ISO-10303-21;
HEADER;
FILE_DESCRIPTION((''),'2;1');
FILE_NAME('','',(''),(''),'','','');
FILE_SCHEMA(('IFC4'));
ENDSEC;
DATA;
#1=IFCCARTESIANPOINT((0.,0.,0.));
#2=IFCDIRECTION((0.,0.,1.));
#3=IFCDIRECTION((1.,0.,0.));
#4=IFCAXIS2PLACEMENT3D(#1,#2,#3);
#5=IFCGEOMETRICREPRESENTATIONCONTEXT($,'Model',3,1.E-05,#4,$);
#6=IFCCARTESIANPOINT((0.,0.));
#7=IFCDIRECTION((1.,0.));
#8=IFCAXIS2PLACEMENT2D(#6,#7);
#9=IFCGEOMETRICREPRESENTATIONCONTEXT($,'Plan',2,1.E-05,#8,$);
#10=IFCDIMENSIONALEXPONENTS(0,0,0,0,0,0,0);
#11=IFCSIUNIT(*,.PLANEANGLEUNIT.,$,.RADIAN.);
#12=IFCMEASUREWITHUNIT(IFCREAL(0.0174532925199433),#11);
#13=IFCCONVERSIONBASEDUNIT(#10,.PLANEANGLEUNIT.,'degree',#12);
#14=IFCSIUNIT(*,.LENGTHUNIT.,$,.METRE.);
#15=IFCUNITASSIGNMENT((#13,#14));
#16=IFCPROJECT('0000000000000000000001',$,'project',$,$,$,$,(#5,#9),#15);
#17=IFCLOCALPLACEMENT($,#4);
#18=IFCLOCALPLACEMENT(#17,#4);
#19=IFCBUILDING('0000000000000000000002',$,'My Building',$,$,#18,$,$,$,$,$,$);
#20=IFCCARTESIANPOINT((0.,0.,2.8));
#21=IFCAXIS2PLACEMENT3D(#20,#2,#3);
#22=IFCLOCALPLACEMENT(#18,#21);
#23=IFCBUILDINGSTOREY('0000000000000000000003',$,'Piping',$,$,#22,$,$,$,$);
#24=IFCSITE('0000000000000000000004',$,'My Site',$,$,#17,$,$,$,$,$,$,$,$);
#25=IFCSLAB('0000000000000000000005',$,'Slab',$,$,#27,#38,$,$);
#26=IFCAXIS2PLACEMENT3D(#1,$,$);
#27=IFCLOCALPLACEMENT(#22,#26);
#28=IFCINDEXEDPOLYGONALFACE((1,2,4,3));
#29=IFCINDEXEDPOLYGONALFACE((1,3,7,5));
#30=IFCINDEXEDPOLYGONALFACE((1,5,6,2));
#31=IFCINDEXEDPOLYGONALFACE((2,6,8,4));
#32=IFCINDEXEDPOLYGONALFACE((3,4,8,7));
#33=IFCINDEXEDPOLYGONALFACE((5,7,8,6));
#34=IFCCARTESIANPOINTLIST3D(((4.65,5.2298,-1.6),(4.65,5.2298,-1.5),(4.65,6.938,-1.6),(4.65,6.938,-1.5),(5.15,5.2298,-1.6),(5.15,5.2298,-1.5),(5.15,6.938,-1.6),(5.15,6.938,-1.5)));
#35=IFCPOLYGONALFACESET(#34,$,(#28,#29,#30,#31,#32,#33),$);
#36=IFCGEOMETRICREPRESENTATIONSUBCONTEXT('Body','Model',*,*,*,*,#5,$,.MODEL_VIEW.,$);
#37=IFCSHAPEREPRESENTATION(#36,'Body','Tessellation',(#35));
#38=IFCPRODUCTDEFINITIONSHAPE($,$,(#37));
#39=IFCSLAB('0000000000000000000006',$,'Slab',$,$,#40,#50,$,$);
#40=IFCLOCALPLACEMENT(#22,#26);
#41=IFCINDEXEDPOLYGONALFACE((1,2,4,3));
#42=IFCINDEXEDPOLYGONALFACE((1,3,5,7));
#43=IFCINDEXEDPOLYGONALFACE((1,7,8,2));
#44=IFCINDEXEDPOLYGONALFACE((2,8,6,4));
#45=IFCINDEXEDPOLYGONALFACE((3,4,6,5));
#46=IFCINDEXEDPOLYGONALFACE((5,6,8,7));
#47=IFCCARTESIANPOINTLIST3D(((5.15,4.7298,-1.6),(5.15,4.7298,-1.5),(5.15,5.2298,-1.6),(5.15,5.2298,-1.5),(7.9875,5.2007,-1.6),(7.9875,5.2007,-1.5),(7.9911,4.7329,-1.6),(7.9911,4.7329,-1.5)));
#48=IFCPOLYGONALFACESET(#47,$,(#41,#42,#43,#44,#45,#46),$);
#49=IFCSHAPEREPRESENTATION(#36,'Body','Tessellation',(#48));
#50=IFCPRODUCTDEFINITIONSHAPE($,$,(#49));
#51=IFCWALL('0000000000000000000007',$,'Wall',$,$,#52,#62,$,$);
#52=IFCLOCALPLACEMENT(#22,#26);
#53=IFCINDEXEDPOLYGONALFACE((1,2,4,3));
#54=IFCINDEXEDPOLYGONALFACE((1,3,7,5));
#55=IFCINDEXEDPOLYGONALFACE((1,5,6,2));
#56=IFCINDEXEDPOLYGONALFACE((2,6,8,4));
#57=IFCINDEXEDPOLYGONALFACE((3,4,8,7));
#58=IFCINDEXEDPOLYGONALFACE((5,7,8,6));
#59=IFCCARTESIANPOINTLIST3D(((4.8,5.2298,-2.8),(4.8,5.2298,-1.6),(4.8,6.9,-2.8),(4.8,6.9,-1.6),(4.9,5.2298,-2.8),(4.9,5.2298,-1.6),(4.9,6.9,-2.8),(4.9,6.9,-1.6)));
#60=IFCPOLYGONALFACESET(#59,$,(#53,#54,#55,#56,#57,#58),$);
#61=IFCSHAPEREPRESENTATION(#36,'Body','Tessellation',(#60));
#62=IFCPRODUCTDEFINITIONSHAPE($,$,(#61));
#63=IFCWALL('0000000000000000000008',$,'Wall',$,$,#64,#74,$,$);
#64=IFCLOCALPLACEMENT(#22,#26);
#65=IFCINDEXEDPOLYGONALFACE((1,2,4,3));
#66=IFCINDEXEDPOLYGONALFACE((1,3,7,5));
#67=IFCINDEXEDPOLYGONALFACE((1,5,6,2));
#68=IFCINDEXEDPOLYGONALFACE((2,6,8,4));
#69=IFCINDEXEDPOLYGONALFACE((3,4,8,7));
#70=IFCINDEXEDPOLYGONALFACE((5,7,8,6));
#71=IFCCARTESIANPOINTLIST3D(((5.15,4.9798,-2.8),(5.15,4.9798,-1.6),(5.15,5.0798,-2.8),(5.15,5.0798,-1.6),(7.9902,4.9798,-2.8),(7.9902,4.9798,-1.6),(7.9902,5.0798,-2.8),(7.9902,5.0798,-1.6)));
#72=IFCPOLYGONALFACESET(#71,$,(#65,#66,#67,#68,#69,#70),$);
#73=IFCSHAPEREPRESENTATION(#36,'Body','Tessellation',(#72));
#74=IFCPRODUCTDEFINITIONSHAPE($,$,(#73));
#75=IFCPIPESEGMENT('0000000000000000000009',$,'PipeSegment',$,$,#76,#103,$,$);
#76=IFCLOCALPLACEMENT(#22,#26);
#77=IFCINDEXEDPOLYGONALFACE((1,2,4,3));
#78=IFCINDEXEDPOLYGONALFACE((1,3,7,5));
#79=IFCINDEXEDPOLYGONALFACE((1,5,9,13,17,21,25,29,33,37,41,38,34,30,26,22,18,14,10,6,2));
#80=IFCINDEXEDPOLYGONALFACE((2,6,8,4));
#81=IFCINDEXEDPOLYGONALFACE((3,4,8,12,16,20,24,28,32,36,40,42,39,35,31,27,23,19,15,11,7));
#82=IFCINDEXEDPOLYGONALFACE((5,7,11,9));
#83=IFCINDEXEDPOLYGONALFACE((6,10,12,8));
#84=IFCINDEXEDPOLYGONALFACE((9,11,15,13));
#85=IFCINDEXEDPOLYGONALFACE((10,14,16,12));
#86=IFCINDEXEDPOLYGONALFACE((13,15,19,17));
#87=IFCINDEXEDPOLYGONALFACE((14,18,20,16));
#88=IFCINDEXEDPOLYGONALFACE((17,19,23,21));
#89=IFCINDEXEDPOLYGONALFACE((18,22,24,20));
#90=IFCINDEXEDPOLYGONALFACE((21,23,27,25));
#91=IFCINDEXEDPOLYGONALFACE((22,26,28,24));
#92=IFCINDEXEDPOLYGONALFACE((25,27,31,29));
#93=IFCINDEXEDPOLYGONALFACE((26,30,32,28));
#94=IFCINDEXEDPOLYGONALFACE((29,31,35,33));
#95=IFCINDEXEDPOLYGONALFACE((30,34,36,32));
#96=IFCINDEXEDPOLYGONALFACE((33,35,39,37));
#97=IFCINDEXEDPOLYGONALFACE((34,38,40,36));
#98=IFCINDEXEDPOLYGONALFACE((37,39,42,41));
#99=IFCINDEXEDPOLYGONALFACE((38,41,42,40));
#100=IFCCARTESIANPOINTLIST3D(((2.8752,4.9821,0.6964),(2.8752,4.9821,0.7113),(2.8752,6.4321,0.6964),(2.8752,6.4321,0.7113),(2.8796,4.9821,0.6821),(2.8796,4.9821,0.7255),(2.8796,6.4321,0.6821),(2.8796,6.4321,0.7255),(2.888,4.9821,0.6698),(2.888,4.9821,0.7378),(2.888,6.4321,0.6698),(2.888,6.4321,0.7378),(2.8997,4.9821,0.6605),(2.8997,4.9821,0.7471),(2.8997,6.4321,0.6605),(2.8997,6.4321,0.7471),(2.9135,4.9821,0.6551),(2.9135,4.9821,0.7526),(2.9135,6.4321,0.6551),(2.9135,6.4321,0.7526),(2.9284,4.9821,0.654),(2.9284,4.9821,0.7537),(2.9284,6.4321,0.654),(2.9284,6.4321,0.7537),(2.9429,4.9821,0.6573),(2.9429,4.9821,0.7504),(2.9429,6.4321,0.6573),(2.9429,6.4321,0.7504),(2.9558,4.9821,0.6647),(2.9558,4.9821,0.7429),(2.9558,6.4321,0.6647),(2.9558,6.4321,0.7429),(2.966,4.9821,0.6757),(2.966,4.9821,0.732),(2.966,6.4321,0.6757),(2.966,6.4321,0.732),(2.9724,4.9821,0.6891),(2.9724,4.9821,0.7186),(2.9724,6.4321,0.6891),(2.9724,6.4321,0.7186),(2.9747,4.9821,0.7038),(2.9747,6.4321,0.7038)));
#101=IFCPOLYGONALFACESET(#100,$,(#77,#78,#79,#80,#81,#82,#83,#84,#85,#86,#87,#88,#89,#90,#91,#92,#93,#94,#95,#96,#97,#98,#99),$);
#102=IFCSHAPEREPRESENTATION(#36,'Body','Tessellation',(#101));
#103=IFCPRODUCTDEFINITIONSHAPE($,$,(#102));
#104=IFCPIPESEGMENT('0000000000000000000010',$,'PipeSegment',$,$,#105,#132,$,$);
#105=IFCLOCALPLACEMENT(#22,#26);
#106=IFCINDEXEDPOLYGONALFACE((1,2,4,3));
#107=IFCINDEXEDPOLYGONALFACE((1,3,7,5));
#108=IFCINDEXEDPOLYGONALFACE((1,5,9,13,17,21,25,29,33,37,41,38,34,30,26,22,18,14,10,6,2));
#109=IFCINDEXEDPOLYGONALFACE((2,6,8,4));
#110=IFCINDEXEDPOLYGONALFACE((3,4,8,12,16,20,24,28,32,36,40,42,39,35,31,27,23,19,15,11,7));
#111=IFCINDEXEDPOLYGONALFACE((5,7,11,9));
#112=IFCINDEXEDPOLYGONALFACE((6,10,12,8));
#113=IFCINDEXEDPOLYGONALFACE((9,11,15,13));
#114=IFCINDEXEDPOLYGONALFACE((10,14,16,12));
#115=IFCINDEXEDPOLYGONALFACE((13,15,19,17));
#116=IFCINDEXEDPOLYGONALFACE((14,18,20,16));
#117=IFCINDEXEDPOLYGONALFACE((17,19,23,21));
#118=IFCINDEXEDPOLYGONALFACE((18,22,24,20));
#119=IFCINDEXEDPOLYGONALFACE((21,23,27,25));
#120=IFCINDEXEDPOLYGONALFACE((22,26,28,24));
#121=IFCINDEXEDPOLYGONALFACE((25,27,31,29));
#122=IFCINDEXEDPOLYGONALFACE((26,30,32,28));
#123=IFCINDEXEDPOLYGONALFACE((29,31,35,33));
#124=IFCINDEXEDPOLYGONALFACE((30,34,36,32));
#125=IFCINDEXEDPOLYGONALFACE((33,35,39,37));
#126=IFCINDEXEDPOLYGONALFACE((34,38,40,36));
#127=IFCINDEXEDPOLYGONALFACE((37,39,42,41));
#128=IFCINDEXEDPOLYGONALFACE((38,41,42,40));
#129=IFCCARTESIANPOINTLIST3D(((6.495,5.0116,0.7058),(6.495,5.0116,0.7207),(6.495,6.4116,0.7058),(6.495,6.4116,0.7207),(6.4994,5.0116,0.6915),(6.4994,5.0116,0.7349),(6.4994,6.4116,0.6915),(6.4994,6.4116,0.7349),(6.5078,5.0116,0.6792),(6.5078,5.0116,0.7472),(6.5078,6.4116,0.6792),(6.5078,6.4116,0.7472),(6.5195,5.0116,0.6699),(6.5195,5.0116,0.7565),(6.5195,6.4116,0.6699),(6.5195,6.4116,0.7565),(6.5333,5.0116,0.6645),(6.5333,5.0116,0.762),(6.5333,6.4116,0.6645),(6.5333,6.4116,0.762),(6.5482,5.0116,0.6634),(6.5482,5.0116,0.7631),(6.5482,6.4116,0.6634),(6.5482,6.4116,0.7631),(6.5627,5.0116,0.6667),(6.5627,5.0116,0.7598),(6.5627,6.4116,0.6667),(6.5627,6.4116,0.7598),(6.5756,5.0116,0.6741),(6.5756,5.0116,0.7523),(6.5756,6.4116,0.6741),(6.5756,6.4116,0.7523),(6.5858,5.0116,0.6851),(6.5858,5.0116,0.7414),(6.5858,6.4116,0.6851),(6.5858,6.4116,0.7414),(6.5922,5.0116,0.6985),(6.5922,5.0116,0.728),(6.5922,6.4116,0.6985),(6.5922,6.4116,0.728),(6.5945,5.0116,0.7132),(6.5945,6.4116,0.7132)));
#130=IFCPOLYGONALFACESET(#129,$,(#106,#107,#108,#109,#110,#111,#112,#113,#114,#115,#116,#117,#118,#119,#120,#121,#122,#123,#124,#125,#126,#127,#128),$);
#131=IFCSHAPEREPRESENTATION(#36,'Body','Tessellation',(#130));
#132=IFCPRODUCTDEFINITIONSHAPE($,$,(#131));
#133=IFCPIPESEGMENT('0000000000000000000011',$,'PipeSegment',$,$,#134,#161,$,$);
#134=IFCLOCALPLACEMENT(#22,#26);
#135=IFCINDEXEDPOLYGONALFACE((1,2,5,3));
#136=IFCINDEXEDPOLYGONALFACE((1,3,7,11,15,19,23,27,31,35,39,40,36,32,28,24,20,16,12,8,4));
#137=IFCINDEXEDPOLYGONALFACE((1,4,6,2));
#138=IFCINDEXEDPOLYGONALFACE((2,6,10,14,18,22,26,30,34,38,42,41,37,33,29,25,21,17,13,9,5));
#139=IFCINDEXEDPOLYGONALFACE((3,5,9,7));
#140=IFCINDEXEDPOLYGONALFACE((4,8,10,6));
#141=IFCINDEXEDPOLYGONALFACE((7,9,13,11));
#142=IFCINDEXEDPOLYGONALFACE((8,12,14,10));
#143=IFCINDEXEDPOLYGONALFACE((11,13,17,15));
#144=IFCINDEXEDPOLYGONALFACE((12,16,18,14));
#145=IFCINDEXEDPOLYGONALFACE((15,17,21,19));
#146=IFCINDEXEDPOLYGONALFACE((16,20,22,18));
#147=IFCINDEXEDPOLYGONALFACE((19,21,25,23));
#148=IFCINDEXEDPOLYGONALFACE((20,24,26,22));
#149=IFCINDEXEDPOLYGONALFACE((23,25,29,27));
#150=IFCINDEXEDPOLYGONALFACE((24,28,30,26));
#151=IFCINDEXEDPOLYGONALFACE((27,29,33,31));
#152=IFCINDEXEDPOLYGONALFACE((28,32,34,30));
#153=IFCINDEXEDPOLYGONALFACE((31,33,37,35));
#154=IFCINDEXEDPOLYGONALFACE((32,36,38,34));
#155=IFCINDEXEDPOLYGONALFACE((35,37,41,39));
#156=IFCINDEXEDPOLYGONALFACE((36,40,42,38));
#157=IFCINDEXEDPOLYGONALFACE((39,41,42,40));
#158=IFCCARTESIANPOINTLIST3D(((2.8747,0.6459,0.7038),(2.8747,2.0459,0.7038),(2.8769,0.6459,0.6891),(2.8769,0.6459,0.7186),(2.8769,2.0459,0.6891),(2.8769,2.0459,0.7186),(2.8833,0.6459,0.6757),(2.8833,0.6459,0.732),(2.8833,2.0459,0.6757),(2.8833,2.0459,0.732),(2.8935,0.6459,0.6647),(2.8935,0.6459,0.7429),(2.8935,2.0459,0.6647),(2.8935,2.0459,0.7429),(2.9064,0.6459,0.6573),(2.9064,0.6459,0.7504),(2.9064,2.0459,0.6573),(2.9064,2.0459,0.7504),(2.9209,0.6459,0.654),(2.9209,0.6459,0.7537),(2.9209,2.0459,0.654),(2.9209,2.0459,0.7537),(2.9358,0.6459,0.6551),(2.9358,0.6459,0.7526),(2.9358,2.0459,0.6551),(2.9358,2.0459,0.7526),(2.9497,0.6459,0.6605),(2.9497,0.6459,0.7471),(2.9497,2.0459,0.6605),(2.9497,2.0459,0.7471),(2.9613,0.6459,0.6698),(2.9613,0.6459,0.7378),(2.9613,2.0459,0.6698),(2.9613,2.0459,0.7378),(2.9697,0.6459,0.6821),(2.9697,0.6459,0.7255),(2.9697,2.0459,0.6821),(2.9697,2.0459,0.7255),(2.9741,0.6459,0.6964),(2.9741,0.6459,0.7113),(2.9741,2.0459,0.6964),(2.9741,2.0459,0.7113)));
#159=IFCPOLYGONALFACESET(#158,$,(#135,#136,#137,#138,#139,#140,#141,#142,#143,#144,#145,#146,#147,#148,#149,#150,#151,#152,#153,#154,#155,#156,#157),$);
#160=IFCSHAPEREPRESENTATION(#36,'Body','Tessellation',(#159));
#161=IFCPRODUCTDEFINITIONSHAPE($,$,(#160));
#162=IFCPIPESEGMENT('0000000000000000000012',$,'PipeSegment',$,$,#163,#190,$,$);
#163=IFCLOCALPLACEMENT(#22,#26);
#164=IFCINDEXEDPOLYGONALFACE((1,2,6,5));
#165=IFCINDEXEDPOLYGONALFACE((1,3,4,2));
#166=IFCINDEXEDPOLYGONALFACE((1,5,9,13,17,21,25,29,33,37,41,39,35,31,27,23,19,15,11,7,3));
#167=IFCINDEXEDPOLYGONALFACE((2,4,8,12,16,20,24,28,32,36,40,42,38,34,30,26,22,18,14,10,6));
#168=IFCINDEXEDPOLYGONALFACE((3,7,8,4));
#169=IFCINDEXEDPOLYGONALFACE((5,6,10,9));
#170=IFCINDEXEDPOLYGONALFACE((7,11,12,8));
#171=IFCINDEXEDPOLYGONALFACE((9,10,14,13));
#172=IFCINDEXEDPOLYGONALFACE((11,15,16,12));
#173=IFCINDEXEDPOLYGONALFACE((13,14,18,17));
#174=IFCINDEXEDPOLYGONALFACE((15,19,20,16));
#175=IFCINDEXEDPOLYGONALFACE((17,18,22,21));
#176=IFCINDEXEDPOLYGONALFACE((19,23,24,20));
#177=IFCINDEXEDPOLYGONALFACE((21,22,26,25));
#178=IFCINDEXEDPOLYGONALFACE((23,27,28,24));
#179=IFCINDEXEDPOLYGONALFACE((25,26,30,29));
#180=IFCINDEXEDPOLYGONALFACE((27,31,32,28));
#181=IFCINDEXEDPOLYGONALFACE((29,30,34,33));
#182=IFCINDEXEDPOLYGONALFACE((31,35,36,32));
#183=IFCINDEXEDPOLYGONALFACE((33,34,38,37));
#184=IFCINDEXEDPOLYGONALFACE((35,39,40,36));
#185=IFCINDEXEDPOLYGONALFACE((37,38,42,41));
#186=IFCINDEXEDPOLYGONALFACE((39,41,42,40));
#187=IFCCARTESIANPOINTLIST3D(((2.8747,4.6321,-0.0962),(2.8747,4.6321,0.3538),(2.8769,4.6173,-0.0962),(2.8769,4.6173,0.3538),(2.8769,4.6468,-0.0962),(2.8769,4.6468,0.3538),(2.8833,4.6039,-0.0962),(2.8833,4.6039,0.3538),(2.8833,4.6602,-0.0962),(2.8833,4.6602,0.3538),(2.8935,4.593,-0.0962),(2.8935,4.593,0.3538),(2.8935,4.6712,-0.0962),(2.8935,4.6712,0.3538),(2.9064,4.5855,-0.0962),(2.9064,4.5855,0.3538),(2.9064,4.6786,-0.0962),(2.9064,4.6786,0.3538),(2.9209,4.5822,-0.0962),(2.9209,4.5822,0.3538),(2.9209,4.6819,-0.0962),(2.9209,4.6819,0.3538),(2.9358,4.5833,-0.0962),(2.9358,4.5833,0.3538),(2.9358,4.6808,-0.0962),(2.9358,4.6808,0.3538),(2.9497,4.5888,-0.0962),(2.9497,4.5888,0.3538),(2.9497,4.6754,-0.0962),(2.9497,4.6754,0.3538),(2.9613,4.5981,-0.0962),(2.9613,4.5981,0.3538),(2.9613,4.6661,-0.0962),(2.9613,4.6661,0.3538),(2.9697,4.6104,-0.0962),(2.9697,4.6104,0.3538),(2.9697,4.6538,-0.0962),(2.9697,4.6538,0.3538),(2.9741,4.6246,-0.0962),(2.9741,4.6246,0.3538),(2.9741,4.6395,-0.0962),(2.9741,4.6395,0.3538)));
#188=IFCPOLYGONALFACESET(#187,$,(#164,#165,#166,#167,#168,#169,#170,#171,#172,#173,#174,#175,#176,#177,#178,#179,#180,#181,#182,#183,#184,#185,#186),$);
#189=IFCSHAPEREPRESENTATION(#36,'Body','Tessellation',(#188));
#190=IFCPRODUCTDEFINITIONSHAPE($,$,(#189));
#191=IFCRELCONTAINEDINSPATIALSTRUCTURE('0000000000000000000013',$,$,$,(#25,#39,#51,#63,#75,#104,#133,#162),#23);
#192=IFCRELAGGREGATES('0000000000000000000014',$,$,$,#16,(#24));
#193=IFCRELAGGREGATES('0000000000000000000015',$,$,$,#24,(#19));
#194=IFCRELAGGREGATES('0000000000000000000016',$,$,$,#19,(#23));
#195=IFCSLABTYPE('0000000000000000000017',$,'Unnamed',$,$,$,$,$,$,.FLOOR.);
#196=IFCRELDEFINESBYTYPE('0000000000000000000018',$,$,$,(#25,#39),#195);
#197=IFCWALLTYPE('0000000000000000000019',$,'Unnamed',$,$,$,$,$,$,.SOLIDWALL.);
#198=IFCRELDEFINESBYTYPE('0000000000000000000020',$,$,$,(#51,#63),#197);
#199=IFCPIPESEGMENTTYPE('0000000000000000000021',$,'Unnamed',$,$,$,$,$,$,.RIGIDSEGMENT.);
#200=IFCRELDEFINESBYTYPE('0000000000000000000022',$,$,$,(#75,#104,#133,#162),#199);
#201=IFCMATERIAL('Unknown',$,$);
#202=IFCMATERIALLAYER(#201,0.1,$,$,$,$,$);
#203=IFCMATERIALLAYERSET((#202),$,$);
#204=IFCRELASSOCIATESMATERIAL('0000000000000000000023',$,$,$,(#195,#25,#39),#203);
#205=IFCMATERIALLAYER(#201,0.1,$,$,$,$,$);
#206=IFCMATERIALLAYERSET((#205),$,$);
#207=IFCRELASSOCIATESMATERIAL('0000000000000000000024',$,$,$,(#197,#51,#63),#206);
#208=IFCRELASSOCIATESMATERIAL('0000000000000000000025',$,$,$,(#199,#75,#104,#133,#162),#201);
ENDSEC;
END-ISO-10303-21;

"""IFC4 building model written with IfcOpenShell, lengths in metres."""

from ifc_helpers import new_model, entity, si_unit, converted_unit, frame, origin_with_axes, origin_2d_with_axis, place, context, subcontext, project, spatial, line, indexed_curve, circle, outline, extrude, material, layer, layer_set, layer_usage, material_profile, profile_set, profile_usage, type_object, element, save


model = new_model("IFC4")

# Units and contexts
model_context = context("Model", 3, precision=1e-05, world=origin_with_axes())
plan_context = context("Plan", 2, precision=1e-05, world=origin_2d_with_axis())
body_context = subcontext(model_context, "Body", "Model", "MODEL_VIEW")
ifc_project = project(units=[converted_unit("PLANEANGLEUNIT", "degree", entity("IfcReal", 0.0174532925199433), si_unit("PLANEANGLEUNIT", "RADIAN"), dimensions=[0, 0, 0, 0, 0, 0, 0]), si_unit("LENGTHUNIT", "METRE")], contexts=[model_context, plan_context])

# Site, building, storey
site_placement = place(None, origin_with_axes())
site = spatial("IfcSite", under=ifc_project, at=site_placement, Name="My Site")
building_placement = place(site_placement, origin_with_axes())
building = spatial("IfcBuilding", under=site, at=building_placement, Name="My Building")
storey_placement = place(building_placement, frame((0.0, 0.0, 2.8), z_axis=(0.0, 0.0, 1.0), x_axis=(1.0, 0.0, 0.0)))
storey = spatial("IfcBuildingStorey", under=building, at=storey_placement, Name="Piping")

# Slabs
ifc_material = material(Name="Unknown")
ifc_layer_1 = layer(ifc_material, 0.1)
ifc_layer_set_1 = layer_set([ifc_layer_1])
ifc_layer_usage_1 = layer_usage(ifc_layer_set_1, "AXIS3", "POSITIVE", -0.1)
slab_type = type_object("IfcSlabType", Name="Unnamed", PredefinedType="FLOOR", material=ifc_layer_set_1)
slab_1_placement = place(storey_placement, frame((5.15, 5.2298, -1.5), z_axis=(0.0, 0.0, 1.0), x_axis=(1.0, 0.0, 0.0)))
element("IfcSlab", 1, at=slab_1_placement, inside=storey, type_object=slab_type, material=ifc_layer_usage_1, Name="Slab", context=body_context, shape_type="SweptSolid", body=[
    extrude(outline(indexed_curve([(0.0, 0.0), (-0.5, 0.0), (-0.5, 1.7083), (0.0, 1.7083), (0.0, 0.0)])), frame((0.0, 0.0, -0.1), z_axis=(0.0, 0.0, 1.0), x_axis=(1.0, 0.0, 0.0)), (0.0, 0.0, 1.0), 0.1),
])
ifc_layer_usage_2 = layer_usage(ifc_layer_set_1, "AXIS3", "POSITIVE", -0.1)
slab_2_placement = place(storey_placement, frame((5.15, 5.2298, -1.5), z_axis=(0.0, 0.0, 1.0), x_axis=(1.0, 0.0, 0.0)))
element("IfcSlab", 2, at=slab_2_placement, inside=storey, type_object=slab_type, material=ifc_layer_usage_2, Name="Slab", context=body_context, shape_type="SweptSolid", body=[
    extrude(outline(indexed_curve([(0.0, 0.0), (0.0, -0.5), (2.8411, -0.4969), (2.8375, -0.0291), (0.0, 0.0)])), frame((0.0, 0.0, -0.1), z_axis=(0.0, 0.0, 1.0), x_axis=(1.0, 0.0, 0.0)), (0.0, 0.0, 1.0), 0.1),
])

# Walls
ifc_layer_2 = layer(ifc_material, 0.1)
ifc_layer_set_2 = layer_set([ifc_layer_2])
ifc_layer_usage_3 = layer_usage(ifc_layer_set_2, "AXIS2", "POSITIVE", 0.0)
wall_type = type_object("IfcWallType", Name="Unnamed", PredefinedType="SOLIDWALL", material=ifc_layer_set_2)
wall_1_placement = place(storey_placement, frame((4.9, 5.2298, -2.8), z_axis=(0.0, 0.0, 1.0), x_axis=(0.0, 1.0, 0.0)))
element("IfcWall", 3, at=wall_1_placement, inside=storey, type_object=wall_type, material=ifc_layer_usage_3, Name="Wall", context=body_context, shape_type="SweptSolid", body=[
    extrude(outline(indexed_curve([(0.0, 0.0), (0.0, 0.1), (1.6703, 0.1), (1.6703, 0.0)], segments=[line(1, 2, 3, 4, 1)])), origin_with_axes(), (0.0, 0.0, 1.0), 1.2),
])
ifc_layer_usage_4 = layer_usage(ifc_layer_set_2, "AXIS2", "POSITIVE", 0.0)
wall_2_placement = place(storey_placement, frame((5.15, 4.9798, -2.8), z_axis=(0.0, 0.0, 1.0), x_axis=(1.0, 0.0, 0.0)))
element("IfcWall", 4, at=wall_2_placement, inside=storey, type_object=wall_type, material=ifc_layer_usage_4, Name="Wall", context=body_context, shape_type="SweptSolid", body=[
    extrude(outline(indexed_curve([(0.0, 0.0), (0.0, 0.1), (2.8402, 0.1), (2.8402, 0.0)], segments=[line(1, 2, 3, 4, 1)])), origin_with_axes(), (0.0, 0.0, 1.0), 1.2),
])

# Pipe segments
ifc_material_profile_1 = material_profile(ifc_material, circle(Radius=0.05))
ifc_profile_set_1 = profile_set([ifc_material_profile_1])
pipe_segment_type = type_object("IfcPipeSegmentType", Name="Unnamed", PredefinedType="RIGIDSEGMENT", material=ifc_profile_set_1)
ifc_profile_usage_1 = profile_usage(ifc_profile_set_1, cardinal=5)
pipe_segment_1_placement = place(storey_placement, frame((2.9247, 6.4321, 0.7038), z_axis=(0.0, -1.0, 0.0), x_axis=(1.0, 0.0, 0.0)))
element("IfcPipeSegment", 5, at=pipe_segment_1_placement, inside=storey, type_object=pipe_segment_type, material=ifc_profile_usage_1, Name="PipeSegment", context=body_context, shape_type="SweptSolid", body=[
    extrude(circle(Radius=0.05), origin_with_axes(), (0.0, 0.0, 1.0), 1.45),
])
ifc_profile_usage_2 = profile_usage(ifc_profile_set_1, cardinal=5)
pipe_segment_2_placement = place(storey_placement, frame((6.5445, 6.4116, 0.7132), z_axis=(0.0, -1.0, 0.0), x_axis=(1.0, 0.0, 0.0)))
element("IfcPipeSegment", 6, at=pipe_segment_2_placement, inside=storey, type_object=pipe_segment_type, material=ifc_profile_usage_2, Name="PipeSegment", context=body_context, shape_type="SweptSolid", body=[
    extrude(circle(Radius=0.05), origin_with_axes(), (0.0, 0.0, 1.0), 1.4),
])
ifc_profile_usage_3 = profile_usage(ifc_profile_set_1, cardinal=5)
pipe_segment_3_placement = place(storey_placement, frame((2.9247, 0.6459, 0.7038), z_axis=(0.0, 1.0, 0.0), x_axis=(-1.0, 0.0, 0.0)))
element("IfcPipeSegment", 7, at=pipe_segment_3_placement, inside=storey, type_object=pipe_segment_type, material=ifc_profile_usage_3, Name="PipeSegment", context=body_context, shape_type="SweptSolid", body=[
    extrude(circle(Radius=0.05), origin_with_axes(), (0.0, 0.0, 1.0), 1.4),
])
ifc_profile_usage_4 = profile_usage(ifc_profile_set_1, cardinal=5)
pipe_segment_4_placement = place(storey_placement, frame((2.9247, 4.6321, 0.3538), z_axis=(0.0, 0.0, -1.0), x_axis=(-1.0, 0.0, 0.0)))
element("IfcPipeSegment", 8, at=pipe_segment_4_placement, inside=storey, type_object=pipe_segment_type, material=ifc_profile_usage_4, Name="PipeSegment", context=body_context, shape_type="SweptSolid", body=[
    extrude(circle(Radius=0.05), origin_with_axes(), (0.0, 0.0, 1.0), 0.45),
])

save(model, "model.ifc")
